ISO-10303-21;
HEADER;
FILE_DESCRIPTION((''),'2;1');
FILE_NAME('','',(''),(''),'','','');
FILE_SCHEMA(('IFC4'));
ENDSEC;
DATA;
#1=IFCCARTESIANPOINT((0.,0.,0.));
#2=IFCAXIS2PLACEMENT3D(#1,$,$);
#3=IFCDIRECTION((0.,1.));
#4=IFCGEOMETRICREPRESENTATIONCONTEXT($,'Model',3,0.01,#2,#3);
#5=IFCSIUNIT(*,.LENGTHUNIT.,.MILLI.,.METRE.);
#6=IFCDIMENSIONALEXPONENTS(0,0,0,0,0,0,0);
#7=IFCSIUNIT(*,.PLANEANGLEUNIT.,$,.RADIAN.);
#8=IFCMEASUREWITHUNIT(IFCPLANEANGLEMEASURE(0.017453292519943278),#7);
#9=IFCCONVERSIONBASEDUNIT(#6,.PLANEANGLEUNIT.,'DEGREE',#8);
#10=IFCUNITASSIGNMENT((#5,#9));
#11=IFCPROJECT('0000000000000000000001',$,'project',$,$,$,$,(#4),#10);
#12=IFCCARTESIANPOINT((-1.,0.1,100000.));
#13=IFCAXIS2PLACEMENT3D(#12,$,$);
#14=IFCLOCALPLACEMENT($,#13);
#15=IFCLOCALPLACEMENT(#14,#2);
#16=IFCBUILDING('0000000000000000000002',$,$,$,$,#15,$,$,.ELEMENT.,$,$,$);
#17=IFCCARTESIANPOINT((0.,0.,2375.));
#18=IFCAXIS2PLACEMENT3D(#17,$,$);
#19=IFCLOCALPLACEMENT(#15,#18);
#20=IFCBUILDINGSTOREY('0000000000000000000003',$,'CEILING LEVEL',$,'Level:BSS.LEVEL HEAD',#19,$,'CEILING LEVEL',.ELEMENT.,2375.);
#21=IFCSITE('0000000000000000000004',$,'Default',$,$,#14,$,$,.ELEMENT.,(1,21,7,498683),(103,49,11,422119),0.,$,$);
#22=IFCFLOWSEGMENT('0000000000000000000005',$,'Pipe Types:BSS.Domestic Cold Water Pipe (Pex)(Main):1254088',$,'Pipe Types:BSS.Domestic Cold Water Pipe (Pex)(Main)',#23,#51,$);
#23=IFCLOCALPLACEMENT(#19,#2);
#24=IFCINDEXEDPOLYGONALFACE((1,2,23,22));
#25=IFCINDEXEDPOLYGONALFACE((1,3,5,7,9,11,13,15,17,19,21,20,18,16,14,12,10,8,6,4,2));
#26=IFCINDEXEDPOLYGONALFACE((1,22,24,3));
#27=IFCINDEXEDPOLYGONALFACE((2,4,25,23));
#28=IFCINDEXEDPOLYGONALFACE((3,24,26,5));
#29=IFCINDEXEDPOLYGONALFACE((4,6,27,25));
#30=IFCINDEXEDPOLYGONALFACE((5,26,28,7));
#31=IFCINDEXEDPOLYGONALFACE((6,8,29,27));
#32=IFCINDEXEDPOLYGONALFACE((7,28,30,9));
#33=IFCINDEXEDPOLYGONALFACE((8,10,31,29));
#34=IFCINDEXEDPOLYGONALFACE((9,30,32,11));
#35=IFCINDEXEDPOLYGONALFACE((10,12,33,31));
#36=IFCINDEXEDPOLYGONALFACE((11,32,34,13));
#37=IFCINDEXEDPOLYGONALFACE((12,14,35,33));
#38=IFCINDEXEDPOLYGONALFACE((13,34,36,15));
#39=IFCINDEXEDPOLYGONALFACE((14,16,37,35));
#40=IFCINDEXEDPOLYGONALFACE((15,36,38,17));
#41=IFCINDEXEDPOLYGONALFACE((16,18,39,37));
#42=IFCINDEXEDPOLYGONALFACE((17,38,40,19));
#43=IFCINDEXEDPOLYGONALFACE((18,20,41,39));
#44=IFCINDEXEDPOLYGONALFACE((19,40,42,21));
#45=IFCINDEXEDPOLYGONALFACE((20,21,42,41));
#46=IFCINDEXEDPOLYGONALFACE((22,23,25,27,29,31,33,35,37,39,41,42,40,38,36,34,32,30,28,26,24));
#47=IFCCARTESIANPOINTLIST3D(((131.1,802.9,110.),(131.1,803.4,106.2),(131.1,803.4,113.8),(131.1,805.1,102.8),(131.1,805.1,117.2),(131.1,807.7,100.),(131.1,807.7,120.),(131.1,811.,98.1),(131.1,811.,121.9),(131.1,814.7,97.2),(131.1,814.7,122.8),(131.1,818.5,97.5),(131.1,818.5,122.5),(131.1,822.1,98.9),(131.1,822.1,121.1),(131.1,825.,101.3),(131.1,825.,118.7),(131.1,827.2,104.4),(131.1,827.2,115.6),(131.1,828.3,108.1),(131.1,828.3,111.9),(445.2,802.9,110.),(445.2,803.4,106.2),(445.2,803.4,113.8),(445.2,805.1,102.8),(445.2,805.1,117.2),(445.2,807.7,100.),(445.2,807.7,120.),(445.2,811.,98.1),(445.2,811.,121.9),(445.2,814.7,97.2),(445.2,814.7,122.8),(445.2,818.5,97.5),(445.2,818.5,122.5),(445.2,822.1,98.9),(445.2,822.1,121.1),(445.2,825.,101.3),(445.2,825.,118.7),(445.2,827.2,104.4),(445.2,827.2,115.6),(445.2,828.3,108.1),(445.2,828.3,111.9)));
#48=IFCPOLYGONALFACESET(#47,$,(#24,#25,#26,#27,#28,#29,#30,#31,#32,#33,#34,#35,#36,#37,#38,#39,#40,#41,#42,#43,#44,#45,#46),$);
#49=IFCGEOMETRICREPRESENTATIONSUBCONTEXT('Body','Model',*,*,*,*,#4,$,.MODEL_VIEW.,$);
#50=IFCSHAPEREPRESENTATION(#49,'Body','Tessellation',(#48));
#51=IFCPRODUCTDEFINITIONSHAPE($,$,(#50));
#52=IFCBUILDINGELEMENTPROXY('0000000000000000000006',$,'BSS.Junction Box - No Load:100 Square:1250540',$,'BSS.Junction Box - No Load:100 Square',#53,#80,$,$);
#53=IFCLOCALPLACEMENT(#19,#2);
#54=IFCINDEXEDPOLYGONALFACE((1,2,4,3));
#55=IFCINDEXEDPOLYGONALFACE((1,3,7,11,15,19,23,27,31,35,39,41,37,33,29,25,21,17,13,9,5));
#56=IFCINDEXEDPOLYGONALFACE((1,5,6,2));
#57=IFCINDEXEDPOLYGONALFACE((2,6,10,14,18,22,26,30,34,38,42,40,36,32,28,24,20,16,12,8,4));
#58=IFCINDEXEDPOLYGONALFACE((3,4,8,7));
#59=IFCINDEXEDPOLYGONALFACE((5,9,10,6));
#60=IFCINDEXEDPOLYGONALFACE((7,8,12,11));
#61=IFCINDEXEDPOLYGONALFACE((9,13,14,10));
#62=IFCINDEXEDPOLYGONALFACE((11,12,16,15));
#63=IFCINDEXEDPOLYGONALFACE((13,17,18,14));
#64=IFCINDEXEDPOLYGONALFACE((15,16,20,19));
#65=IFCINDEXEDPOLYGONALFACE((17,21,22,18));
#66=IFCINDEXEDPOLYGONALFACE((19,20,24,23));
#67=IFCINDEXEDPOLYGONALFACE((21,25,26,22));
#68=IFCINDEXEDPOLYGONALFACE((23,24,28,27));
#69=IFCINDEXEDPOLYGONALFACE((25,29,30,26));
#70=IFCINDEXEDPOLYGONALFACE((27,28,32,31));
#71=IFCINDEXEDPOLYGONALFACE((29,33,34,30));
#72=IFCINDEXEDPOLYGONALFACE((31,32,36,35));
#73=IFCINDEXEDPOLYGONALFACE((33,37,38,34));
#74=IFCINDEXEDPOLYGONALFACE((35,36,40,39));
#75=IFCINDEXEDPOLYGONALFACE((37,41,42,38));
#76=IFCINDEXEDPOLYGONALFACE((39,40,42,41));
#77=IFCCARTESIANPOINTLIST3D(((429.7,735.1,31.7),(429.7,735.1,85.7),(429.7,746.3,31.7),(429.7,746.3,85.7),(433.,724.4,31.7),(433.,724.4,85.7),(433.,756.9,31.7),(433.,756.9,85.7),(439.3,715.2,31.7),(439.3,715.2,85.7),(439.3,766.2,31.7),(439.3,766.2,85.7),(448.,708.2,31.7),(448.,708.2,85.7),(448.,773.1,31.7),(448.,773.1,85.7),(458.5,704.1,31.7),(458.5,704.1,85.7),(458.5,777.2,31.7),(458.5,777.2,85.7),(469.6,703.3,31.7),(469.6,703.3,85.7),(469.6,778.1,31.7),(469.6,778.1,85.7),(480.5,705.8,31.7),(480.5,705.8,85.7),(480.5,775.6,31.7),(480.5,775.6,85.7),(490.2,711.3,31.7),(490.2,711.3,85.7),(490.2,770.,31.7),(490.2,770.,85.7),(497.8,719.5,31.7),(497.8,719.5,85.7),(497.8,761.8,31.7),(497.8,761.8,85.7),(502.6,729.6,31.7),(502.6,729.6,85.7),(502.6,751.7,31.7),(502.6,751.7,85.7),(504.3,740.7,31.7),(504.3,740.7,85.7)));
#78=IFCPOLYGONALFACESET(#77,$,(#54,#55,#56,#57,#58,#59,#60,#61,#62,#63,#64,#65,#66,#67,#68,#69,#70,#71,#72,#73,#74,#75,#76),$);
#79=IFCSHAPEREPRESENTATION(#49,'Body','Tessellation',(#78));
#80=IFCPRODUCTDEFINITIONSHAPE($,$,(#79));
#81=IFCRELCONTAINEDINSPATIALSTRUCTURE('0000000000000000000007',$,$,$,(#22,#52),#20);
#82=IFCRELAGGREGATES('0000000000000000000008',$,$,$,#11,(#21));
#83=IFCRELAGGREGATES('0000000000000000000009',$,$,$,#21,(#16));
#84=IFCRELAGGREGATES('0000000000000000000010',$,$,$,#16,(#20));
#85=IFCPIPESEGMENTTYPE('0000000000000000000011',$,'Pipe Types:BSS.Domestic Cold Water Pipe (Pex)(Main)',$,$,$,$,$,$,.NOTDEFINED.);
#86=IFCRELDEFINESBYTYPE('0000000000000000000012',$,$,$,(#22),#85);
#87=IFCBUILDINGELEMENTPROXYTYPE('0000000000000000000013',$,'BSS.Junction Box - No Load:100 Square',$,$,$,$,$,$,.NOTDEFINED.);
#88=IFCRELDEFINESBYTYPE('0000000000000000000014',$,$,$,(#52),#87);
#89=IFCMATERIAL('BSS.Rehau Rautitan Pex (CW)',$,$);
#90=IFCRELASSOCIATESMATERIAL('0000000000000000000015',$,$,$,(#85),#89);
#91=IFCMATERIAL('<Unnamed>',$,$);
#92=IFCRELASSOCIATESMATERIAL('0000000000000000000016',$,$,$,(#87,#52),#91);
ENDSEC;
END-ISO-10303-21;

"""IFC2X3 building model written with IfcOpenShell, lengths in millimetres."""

from ifc_helpers import new_model, entity, si_unit, converted_unit, direction, frame, frame_2d, origin, origin_2d_with_axis, place, context, subcontext, project, spatial, circle, extrude, source, transform, mapped, material, type_object, type_shapes, element, save


model = new_model("IFC2X3")

# Units and contexts
model_context = context("Model", 3, precision=0.01, world=origin(), true_north=direction((0.0, 1.0)))
body_context = subcontext(model_context, "Body", "Model", "MODEL_VIEW")
ifc_project = project(units=[si_unit("LENGTHUNIT", "METRE", prefix="MILLI"), converted_unit("PLANEANGLEUNIT", "DEGREE", entity("IfcPlaneAngleMeasure", 0.017453292519943278), si_unit("PLANEANGLEUNIT", "RADIAN"), dimensions=[0, 0, 0, 0, 0, 0, 0])], contexts=[model_context])

# Site, building, storey
site_placement = place(None, frame((-1.0, 0.1, 100000.0)))
site = spatial("IfcSite", under=ifc_project, at=site_placement, Name="Default", CompositionType="ELEMENT", RefLatitude=(1, 21, 7, 498683), RefLongitude=(103, 49, 11, 422119), RefElevation=0.0)
building_placement = place(site_placement, origin())
building = spatial("IfcBuilding", under=site, at=building_placement, CompositionType="ELEMENT")
storey_placement = place(building_placement, frame((0.0, 0.0, 2375.0)))
storey = spatial("IfcBuildingStorey", under=building, at=storey_placement, Name="CEILING LEVEL", ObjectType="Level:BSS.LEVEL HEAD", LongName="CEILING LEVEL", CompositionType="ELEMENT", Elevation=2375.0)

# Flow segment
ifc_material_1 = material(Name="BSS.Rehau Rautitan Pex (CW)")
pipe_segment_type_1 = type_object("IfcPipeSegmentType", Name="Pipe Types:BSS.Domestic Cold Water Pipe (Pex)(Main)", PredefinedType="NOTDEFINED", material=ifc_material_1)
flow_segment_1_placement = place(storey_placement, origin())
element("IfcFlowSegment", 1, at=flow_segment_1_placement, inside=storey, type_object=pipe_segment_type_1, Name="Pipe Types:BSS.Domestic Cold Water Pipe (Pex)(Main):1254088", ObjectType="Pipe Types:BSS.Domestic Cold Water Pipe (Pex)(Main)", context=body_context, shape_type="SweptSolid", body=[
    extrude(circle(Radius=12.8, at=origin_2d_with_axis()), frame((131.1, 815.7, 110.0), z_axis=(1.0, 0.0, 0.0), x_axis=(0.0, -1.0, 0.0)), (0.0, 0.0, 1.0), 314.1),
])

# Building element proxy
ifc_material_2 = material(Name="<Unnamed>")
building_element_proxy_type = type_object("IfcBuildingElementProxyType", Name="BSS.Junction Box - No Load:100 Square", PredefinedType="NOTDEFINED", material=ifc_material_2)
shared_shape = source(origin(), body_context, "Body", "SweptSolid", [
    extrude(circle(Radius=37.5, at=frame_2d((0.0, 0.0), x_axis=(1.0, 0.0))), origin(), (0.0, 0.0, 1.0), 54.0),
])
type_shapes(building_element_proxy_type, [shared_shape])
proxy_placement = place(storey_placement, frame((466.8, 740.7, 31.7)))
element("IfcBuildingElementProxy", 2, at=proxy_placement, inside=storey, type_object=building_element_proxy_type, material=ifc_material_2, Name="BSS.Junction Box - No Load:100 Square:1250540", ObjectType="BSS.Junction Box - No Load:100 Square", context=body_context, shape_type="MappedRepresentation", body=[
    mapped(shared_shape, transform((0.0, 0.0, 0.0), scale=1.0)),
])

save(model, "model.ifc")
